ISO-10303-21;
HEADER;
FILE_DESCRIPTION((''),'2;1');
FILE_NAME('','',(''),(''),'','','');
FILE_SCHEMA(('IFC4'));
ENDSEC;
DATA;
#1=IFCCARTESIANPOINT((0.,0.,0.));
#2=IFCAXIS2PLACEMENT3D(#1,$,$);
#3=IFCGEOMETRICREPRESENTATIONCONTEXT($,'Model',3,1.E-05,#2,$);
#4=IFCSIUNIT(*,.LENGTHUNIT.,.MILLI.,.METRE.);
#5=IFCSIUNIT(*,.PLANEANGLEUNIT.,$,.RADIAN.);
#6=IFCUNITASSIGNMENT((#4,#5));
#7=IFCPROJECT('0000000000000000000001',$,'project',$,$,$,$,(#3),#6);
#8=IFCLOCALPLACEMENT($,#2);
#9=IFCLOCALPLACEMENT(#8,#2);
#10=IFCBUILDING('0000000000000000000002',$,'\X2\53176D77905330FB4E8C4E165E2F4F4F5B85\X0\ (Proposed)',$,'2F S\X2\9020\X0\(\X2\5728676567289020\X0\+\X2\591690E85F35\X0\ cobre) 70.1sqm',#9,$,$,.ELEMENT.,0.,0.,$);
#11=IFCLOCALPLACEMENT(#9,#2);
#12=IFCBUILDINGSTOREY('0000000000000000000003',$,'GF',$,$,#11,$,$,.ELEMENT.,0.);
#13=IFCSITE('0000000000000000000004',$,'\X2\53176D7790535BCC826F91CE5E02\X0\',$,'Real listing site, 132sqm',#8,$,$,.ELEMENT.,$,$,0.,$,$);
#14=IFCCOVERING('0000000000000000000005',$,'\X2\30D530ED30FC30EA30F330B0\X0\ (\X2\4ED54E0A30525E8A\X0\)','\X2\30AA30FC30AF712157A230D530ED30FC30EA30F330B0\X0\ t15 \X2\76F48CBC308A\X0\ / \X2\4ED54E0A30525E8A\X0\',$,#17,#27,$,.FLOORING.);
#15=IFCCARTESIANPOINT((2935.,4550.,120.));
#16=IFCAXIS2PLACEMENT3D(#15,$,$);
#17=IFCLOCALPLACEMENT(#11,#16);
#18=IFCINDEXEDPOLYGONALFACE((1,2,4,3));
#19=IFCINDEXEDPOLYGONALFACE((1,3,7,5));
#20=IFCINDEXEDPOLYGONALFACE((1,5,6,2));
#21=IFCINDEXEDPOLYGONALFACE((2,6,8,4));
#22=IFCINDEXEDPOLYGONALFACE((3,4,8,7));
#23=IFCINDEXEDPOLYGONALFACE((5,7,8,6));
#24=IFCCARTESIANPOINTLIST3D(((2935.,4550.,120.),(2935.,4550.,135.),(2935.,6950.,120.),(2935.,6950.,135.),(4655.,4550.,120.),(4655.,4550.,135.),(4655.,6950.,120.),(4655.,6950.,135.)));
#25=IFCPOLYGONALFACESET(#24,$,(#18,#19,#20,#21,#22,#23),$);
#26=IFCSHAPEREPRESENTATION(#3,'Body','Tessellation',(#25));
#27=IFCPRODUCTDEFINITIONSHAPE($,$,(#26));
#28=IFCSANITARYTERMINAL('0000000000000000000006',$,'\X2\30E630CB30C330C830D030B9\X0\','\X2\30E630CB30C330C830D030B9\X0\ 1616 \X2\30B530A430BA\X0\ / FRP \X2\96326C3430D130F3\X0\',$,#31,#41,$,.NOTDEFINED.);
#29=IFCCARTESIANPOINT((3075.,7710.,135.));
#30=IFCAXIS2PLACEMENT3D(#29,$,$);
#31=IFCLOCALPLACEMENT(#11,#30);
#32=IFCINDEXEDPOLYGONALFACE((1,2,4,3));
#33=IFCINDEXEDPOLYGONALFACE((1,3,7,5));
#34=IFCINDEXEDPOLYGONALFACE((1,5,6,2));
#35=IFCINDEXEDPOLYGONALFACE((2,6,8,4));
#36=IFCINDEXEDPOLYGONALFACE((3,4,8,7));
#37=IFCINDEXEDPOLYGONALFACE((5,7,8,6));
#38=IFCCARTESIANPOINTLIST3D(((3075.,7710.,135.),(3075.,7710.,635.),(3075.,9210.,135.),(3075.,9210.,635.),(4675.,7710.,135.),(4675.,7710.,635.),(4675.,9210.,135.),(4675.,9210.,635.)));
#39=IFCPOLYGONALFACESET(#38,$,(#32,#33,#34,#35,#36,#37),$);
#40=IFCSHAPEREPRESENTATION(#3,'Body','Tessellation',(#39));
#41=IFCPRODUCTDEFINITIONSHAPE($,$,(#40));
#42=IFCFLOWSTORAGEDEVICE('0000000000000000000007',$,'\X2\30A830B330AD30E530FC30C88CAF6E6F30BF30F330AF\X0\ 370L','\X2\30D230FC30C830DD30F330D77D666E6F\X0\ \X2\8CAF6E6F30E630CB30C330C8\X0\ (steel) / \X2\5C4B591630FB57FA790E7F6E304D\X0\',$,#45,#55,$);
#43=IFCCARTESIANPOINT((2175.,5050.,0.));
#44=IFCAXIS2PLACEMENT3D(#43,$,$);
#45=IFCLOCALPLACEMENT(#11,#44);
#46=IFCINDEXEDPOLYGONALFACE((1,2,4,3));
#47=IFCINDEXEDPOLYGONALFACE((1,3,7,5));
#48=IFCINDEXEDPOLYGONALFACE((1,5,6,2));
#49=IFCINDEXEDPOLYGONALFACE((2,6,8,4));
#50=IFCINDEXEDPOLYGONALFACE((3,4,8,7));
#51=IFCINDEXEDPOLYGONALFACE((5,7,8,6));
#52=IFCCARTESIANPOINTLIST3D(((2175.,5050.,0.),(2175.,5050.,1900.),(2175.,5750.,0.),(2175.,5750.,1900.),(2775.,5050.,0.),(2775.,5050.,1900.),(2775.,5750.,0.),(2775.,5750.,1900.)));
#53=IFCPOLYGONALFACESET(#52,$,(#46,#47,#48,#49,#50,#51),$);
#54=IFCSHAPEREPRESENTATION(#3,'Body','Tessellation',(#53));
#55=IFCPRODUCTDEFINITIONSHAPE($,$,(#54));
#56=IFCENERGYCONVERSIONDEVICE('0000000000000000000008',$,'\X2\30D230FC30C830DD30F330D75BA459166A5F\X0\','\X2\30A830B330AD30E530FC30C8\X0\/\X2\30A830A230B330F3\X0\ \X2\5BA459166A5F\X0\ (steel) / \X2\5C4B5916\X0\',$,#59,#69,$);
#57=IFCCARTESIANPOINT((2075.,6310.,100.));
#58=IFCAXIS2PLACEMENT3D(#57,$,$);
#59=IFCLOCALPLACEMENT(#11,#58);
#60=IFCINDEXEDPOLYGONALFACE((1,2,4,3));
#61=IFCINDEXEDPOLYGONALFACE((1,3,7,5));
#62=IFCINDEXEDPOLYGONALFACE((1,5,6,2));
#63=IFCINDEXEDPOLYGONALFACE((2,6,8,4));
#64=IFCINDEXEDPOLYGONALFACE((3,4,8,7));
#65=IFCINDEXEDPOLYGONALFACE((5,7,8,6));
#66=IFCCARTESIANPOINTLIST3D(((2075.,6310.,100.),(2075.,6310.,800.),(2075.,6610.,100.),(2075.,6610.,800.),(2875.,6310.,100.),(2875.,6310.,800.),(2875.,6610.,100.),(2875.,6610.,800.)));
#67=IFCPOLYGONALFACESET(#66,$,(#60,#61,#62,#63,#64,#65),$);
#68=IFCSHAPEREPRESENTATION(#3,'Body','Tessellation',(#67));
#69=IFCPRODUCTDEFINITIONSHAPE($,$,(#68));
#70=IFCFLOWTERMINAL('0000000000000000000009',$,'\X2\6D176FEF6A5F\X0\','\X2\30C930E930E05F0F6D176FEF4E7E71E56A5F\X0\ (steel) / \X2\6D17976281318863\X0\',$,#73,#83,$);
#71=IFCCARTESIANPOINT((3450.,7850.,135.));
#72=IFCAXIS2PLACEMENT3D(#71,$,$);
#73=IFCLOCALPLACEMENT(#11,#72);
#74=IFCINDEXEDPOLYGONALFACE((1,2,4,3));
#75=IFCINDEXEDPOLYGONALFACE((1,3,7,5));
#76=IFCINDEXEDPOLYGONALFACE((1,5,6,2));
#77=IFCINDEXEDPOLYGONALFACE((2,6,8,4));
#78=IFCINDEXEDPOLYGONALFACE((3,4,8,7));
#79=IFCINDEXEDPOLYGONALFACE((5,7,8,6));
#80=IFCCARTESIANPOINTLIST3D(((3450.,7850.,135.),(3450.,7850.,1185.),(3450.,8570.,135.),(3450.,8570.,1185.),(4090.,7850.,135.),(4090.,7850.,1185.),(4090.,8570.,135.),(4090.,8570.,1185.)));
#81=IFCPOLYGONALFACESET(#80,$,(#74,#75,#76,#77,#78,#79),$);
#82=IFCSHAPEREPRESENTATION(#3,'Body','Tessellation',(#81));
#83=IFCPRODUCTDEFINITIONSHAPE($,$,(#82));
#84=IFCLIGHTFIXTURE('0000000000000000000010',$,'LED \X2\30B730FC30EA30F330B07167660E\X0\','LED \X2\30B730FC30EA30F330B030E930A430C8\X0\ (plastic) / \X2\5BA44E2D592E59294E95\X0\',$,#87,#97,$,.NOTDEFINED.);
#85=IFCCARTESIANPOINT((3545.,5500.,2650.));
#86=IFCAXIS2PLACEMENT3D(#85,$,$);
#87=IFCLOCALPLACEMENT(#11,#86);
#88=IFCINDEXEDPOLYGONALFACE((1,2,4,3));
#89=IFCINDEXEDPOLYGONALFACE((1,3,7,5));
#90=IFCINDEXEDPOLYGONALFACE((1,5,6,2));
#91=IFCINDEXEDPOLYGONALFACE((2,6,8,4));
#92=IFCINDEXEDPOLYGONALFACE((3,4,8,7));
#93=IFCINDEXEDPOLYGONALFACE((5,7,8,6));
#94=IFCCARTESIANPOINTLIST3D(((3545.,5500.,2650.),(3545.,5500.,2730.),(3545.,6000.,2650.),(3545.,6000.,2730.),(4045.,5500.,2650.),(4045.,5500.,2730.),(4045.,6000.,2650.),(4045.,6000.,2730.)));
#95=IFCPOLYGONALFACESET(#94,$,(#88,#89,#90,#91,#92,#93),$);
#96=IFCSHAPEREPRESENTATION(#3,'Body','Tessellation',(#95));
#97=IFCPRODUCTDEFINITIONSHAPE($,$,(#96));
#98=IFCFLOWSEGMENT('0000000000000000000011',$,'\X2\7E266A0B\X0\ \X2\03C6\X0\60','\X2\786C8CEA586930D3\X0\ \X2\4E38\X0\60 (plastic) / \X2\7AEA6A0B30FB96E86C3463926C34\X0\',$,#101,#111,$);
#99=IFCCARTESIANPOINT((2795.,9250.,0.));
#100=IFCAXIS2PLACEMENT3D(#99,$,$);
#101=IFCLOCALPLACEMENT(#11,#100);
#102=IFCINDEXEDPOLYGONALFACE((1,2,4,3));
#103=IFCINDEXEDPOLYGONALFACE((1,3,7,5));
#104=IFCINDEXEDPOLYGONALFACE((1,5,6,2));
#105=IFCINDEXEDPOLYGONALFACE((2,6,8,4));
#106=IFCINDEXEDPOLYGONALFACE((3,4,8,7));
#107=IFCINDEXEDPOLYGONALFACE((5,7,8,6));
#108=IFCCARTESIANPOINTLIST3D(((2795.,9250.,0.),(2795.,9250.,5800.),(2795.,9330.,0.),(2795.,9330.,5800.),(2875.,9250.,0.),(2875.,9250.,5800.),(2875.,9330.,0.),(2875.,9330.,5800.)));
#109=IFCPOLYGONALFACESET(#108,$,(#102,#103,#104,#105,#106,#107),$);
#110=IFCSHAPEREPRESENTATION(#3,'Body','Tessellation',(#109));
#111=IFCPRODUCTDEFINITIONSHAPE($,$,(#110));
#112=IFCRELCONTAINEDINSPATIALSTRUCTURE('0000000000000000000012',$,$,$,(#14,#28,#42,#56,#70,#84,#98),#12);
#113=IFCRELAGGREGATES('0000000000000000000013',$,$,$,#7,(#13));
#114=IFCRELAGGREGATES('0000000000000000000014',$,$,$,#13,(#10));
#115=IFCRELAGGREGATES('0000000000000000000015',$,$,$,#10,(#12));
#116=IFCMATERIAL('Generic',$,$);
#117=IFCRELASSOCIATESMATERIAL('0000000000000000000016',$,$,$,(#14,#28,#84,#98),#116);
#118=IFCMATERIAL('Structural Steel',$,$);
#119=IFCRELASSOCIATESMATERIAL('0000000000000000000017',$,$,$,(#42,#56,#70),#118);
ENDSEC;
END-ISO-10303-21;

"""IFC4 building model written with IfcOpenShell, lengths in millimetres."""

from ifc_helpers import new_model, si_unit, frame, frame_2d, origin, place, context, project, spatial, rectangle, extrude, material, element, save


model = new_model("IFC4")

# Units and contexts
model_context = context("Model", 3, precision=1e-05, world=origin())
ifc_project = project(units=[si_unit("LENGTHUNIT", "METRE", prefix="MILLI"), si_unit("PLANEANGLEUNIT", "RADIAN")], contexts=[model_context])

# Site, building, storey
site_placement = place(None, origin())
site = spatial("IfcSite", under=ifc_project, at=site_placement, Name="北海道富良野市", ObjectType="Real listing site, 132sqm", CompositionType="ELEMENT", RefElevation=0.0)
building_placement = place(site_placement, origin())
building = spatial("IfcBuilding", under=site, at=building_placement, Name="北海道・二世帯住宅 (Proposed)", ObjectType="2F S造(在来木造+外部張 cobre) 70.1sqm", CompositionType="ELEMENT", ElevationOfRefHeight=0.0, ElevationOfTerrain=0.0)
storey_placement = place(building_placement, origin())
storey = spatial("IfcBuildingStorey", under=building, at=storey_placement, Name="GF", CompositionType="ELEMENT", Elevation=0.0)

# Covering
ifc_material_1 = material(Name="Generic")
covering_1_placement = place(storey_placement, frame((2935.0, 4550.0, 120.0)))
element("IfcCovering", 1, at=covering_1_placement, inside=storey, material=ifc_material_1, Name="フローリング (仕上げ床)", Description="オーク無垢フローリング t15 直貼り / 仕上げ床", PredefinedType="FLOORING", context=model_context, shape_type="SweptSolid", body=[
    extrude(rectangle(XDim=1720.0, YDim=2400.0, at=frame_2d((860.0, 1200.0))), frame((2935.0, 4550.0, 120.0)), (0.0, 0.0, 1.0), 15.0),
])

# Sanitary terminal
sanitary_terminal_placement = place(storey_placement, frame((3075.0, 7710.0, 135.0)))
element("IfcSanitaryTerminal", 2, at=sanitary_terminal_placement, inside=storey, material=ifc_material_1, Name="ユニットバス", Description="ユニットバス 1616 サイズ / FRP 防水パン", PredefinedType="NOTDEFINED", context=model_context, shape_type="SweptSolid", body=[
    extrude(rectangle(XDim=1600.0, YDim=1500.0, at=frame_2d((800.0, 750.0))), frame((3075.0, 7710.0, 135.0)), (0.0, 0.0, 1.0), 500.0),
])

# Flow storage device
ifc_material_2 = material(Name="Structural Steel")
flow_storage_device_placement = place(storey_placement, frame((2175.0, 5050.0, 0.0)))
element("IfcFlowStorageDevice", 3, at=flow_storage_device_placement, inside=storey, material=ifc_material_2, Name="エコキュート貯湯タンク 370L", Description="ヒートポンプ給湯 貯湯ユニット (steel) / 屋外・基礎置き", context=model_context, shape_type="SweptSolid", body=[
    extrude(rectangle(XDim=600.0, YDim=700.0, at=frame_2d((300.0, 350.0))), frame((2175.0, 5050.0, 0.0)), (0.0, 0.0, 1.0), 1900.0),
])

# Energy conversion device
energy_conversion_device_placement = place(storey_placement, frame((2075.0, 6310.0, 100.0)))
element("IfcEnergyConversionDevice", 4, at=energy_conversion_device_placement, inside=storey, material=ifc_material_2, Name="ヒートポンプ室外機", Description="エコキュート/エアコン 室外機 (steel) / 屋外", context=model_context, shape_type="SweptSolid", body=[
    extrude(rectangle(XDim=800.0, YDim=300.0, at=frame_2d((400.0, 150.0))), frame((2075.0, 6310.0, 100.0)), (0.0, 0.0, 1.0), 700.0),
])

# Flow terminal
flow_terminal_placement = place(storey_placement, frame((3450.0, 7850.0, 135.0)))
element("IfcFlowTerminal", 5, at=flow_terminal_placement, inside=storey, material=ifc_material_2, Name="洗濯機", Description="ドラム式洗濯乾燥機 (steel) / 洗面脱衣", context=model_context, shape_type="SweptSolid", body=[
    extrude(rectangle(XDim=640.0, YDim=720.0, at=frame_2d((320.0, 360.0))), frame((3450.0, 7850.0, 135.0)), (0.0, 0.0, 1.0), 1050.0),
])

# Light fixture
light_fixture_placement = place(storey_placement, frame((3545.0, 5500.0, 2650.0)))
element("IfcLightFixture", 6, at=light_fixture_placement, inside=storey, material=ifc_material_1, Name="LED シーリング照明", Description="LED シーリングライト (plastic) / 室中央天井", PredefinedType="NOTDEFINED", context=model_context, shape_type="SweptSolid", body=[
    extrude(rectangle(XDim=500.0, YDim=500.0, at=frame_2d((250.0, 250.0))), frame((3545.0, 5500.0, 2650.0)), (0.0, 0.0, 1.0), 80.0),
])

# Flow segment
flow_segment_placement = place(storey_placement, frame((2795.0, 9250.0, 0.0)))
element("IfcFlowSegment", 7, at=flow_segment_placement, inside=storey, material=ifc_material_1, Name="縦樋 φ60", Description="硬質塩ビ 丸60 (plastic) / 竪樋・雨水排水", context=model_context, shape_type="SweptSolid", body=[
    extrude(rectangle(XDim=80.0, YDim=80.0, at=frame_2d((40.0, 40.0))), frame((2795.0, 9250.0, 0.0)), (0.0, 0.0, 1.0), 5800.0),
])

save(model, "model.ifc")
